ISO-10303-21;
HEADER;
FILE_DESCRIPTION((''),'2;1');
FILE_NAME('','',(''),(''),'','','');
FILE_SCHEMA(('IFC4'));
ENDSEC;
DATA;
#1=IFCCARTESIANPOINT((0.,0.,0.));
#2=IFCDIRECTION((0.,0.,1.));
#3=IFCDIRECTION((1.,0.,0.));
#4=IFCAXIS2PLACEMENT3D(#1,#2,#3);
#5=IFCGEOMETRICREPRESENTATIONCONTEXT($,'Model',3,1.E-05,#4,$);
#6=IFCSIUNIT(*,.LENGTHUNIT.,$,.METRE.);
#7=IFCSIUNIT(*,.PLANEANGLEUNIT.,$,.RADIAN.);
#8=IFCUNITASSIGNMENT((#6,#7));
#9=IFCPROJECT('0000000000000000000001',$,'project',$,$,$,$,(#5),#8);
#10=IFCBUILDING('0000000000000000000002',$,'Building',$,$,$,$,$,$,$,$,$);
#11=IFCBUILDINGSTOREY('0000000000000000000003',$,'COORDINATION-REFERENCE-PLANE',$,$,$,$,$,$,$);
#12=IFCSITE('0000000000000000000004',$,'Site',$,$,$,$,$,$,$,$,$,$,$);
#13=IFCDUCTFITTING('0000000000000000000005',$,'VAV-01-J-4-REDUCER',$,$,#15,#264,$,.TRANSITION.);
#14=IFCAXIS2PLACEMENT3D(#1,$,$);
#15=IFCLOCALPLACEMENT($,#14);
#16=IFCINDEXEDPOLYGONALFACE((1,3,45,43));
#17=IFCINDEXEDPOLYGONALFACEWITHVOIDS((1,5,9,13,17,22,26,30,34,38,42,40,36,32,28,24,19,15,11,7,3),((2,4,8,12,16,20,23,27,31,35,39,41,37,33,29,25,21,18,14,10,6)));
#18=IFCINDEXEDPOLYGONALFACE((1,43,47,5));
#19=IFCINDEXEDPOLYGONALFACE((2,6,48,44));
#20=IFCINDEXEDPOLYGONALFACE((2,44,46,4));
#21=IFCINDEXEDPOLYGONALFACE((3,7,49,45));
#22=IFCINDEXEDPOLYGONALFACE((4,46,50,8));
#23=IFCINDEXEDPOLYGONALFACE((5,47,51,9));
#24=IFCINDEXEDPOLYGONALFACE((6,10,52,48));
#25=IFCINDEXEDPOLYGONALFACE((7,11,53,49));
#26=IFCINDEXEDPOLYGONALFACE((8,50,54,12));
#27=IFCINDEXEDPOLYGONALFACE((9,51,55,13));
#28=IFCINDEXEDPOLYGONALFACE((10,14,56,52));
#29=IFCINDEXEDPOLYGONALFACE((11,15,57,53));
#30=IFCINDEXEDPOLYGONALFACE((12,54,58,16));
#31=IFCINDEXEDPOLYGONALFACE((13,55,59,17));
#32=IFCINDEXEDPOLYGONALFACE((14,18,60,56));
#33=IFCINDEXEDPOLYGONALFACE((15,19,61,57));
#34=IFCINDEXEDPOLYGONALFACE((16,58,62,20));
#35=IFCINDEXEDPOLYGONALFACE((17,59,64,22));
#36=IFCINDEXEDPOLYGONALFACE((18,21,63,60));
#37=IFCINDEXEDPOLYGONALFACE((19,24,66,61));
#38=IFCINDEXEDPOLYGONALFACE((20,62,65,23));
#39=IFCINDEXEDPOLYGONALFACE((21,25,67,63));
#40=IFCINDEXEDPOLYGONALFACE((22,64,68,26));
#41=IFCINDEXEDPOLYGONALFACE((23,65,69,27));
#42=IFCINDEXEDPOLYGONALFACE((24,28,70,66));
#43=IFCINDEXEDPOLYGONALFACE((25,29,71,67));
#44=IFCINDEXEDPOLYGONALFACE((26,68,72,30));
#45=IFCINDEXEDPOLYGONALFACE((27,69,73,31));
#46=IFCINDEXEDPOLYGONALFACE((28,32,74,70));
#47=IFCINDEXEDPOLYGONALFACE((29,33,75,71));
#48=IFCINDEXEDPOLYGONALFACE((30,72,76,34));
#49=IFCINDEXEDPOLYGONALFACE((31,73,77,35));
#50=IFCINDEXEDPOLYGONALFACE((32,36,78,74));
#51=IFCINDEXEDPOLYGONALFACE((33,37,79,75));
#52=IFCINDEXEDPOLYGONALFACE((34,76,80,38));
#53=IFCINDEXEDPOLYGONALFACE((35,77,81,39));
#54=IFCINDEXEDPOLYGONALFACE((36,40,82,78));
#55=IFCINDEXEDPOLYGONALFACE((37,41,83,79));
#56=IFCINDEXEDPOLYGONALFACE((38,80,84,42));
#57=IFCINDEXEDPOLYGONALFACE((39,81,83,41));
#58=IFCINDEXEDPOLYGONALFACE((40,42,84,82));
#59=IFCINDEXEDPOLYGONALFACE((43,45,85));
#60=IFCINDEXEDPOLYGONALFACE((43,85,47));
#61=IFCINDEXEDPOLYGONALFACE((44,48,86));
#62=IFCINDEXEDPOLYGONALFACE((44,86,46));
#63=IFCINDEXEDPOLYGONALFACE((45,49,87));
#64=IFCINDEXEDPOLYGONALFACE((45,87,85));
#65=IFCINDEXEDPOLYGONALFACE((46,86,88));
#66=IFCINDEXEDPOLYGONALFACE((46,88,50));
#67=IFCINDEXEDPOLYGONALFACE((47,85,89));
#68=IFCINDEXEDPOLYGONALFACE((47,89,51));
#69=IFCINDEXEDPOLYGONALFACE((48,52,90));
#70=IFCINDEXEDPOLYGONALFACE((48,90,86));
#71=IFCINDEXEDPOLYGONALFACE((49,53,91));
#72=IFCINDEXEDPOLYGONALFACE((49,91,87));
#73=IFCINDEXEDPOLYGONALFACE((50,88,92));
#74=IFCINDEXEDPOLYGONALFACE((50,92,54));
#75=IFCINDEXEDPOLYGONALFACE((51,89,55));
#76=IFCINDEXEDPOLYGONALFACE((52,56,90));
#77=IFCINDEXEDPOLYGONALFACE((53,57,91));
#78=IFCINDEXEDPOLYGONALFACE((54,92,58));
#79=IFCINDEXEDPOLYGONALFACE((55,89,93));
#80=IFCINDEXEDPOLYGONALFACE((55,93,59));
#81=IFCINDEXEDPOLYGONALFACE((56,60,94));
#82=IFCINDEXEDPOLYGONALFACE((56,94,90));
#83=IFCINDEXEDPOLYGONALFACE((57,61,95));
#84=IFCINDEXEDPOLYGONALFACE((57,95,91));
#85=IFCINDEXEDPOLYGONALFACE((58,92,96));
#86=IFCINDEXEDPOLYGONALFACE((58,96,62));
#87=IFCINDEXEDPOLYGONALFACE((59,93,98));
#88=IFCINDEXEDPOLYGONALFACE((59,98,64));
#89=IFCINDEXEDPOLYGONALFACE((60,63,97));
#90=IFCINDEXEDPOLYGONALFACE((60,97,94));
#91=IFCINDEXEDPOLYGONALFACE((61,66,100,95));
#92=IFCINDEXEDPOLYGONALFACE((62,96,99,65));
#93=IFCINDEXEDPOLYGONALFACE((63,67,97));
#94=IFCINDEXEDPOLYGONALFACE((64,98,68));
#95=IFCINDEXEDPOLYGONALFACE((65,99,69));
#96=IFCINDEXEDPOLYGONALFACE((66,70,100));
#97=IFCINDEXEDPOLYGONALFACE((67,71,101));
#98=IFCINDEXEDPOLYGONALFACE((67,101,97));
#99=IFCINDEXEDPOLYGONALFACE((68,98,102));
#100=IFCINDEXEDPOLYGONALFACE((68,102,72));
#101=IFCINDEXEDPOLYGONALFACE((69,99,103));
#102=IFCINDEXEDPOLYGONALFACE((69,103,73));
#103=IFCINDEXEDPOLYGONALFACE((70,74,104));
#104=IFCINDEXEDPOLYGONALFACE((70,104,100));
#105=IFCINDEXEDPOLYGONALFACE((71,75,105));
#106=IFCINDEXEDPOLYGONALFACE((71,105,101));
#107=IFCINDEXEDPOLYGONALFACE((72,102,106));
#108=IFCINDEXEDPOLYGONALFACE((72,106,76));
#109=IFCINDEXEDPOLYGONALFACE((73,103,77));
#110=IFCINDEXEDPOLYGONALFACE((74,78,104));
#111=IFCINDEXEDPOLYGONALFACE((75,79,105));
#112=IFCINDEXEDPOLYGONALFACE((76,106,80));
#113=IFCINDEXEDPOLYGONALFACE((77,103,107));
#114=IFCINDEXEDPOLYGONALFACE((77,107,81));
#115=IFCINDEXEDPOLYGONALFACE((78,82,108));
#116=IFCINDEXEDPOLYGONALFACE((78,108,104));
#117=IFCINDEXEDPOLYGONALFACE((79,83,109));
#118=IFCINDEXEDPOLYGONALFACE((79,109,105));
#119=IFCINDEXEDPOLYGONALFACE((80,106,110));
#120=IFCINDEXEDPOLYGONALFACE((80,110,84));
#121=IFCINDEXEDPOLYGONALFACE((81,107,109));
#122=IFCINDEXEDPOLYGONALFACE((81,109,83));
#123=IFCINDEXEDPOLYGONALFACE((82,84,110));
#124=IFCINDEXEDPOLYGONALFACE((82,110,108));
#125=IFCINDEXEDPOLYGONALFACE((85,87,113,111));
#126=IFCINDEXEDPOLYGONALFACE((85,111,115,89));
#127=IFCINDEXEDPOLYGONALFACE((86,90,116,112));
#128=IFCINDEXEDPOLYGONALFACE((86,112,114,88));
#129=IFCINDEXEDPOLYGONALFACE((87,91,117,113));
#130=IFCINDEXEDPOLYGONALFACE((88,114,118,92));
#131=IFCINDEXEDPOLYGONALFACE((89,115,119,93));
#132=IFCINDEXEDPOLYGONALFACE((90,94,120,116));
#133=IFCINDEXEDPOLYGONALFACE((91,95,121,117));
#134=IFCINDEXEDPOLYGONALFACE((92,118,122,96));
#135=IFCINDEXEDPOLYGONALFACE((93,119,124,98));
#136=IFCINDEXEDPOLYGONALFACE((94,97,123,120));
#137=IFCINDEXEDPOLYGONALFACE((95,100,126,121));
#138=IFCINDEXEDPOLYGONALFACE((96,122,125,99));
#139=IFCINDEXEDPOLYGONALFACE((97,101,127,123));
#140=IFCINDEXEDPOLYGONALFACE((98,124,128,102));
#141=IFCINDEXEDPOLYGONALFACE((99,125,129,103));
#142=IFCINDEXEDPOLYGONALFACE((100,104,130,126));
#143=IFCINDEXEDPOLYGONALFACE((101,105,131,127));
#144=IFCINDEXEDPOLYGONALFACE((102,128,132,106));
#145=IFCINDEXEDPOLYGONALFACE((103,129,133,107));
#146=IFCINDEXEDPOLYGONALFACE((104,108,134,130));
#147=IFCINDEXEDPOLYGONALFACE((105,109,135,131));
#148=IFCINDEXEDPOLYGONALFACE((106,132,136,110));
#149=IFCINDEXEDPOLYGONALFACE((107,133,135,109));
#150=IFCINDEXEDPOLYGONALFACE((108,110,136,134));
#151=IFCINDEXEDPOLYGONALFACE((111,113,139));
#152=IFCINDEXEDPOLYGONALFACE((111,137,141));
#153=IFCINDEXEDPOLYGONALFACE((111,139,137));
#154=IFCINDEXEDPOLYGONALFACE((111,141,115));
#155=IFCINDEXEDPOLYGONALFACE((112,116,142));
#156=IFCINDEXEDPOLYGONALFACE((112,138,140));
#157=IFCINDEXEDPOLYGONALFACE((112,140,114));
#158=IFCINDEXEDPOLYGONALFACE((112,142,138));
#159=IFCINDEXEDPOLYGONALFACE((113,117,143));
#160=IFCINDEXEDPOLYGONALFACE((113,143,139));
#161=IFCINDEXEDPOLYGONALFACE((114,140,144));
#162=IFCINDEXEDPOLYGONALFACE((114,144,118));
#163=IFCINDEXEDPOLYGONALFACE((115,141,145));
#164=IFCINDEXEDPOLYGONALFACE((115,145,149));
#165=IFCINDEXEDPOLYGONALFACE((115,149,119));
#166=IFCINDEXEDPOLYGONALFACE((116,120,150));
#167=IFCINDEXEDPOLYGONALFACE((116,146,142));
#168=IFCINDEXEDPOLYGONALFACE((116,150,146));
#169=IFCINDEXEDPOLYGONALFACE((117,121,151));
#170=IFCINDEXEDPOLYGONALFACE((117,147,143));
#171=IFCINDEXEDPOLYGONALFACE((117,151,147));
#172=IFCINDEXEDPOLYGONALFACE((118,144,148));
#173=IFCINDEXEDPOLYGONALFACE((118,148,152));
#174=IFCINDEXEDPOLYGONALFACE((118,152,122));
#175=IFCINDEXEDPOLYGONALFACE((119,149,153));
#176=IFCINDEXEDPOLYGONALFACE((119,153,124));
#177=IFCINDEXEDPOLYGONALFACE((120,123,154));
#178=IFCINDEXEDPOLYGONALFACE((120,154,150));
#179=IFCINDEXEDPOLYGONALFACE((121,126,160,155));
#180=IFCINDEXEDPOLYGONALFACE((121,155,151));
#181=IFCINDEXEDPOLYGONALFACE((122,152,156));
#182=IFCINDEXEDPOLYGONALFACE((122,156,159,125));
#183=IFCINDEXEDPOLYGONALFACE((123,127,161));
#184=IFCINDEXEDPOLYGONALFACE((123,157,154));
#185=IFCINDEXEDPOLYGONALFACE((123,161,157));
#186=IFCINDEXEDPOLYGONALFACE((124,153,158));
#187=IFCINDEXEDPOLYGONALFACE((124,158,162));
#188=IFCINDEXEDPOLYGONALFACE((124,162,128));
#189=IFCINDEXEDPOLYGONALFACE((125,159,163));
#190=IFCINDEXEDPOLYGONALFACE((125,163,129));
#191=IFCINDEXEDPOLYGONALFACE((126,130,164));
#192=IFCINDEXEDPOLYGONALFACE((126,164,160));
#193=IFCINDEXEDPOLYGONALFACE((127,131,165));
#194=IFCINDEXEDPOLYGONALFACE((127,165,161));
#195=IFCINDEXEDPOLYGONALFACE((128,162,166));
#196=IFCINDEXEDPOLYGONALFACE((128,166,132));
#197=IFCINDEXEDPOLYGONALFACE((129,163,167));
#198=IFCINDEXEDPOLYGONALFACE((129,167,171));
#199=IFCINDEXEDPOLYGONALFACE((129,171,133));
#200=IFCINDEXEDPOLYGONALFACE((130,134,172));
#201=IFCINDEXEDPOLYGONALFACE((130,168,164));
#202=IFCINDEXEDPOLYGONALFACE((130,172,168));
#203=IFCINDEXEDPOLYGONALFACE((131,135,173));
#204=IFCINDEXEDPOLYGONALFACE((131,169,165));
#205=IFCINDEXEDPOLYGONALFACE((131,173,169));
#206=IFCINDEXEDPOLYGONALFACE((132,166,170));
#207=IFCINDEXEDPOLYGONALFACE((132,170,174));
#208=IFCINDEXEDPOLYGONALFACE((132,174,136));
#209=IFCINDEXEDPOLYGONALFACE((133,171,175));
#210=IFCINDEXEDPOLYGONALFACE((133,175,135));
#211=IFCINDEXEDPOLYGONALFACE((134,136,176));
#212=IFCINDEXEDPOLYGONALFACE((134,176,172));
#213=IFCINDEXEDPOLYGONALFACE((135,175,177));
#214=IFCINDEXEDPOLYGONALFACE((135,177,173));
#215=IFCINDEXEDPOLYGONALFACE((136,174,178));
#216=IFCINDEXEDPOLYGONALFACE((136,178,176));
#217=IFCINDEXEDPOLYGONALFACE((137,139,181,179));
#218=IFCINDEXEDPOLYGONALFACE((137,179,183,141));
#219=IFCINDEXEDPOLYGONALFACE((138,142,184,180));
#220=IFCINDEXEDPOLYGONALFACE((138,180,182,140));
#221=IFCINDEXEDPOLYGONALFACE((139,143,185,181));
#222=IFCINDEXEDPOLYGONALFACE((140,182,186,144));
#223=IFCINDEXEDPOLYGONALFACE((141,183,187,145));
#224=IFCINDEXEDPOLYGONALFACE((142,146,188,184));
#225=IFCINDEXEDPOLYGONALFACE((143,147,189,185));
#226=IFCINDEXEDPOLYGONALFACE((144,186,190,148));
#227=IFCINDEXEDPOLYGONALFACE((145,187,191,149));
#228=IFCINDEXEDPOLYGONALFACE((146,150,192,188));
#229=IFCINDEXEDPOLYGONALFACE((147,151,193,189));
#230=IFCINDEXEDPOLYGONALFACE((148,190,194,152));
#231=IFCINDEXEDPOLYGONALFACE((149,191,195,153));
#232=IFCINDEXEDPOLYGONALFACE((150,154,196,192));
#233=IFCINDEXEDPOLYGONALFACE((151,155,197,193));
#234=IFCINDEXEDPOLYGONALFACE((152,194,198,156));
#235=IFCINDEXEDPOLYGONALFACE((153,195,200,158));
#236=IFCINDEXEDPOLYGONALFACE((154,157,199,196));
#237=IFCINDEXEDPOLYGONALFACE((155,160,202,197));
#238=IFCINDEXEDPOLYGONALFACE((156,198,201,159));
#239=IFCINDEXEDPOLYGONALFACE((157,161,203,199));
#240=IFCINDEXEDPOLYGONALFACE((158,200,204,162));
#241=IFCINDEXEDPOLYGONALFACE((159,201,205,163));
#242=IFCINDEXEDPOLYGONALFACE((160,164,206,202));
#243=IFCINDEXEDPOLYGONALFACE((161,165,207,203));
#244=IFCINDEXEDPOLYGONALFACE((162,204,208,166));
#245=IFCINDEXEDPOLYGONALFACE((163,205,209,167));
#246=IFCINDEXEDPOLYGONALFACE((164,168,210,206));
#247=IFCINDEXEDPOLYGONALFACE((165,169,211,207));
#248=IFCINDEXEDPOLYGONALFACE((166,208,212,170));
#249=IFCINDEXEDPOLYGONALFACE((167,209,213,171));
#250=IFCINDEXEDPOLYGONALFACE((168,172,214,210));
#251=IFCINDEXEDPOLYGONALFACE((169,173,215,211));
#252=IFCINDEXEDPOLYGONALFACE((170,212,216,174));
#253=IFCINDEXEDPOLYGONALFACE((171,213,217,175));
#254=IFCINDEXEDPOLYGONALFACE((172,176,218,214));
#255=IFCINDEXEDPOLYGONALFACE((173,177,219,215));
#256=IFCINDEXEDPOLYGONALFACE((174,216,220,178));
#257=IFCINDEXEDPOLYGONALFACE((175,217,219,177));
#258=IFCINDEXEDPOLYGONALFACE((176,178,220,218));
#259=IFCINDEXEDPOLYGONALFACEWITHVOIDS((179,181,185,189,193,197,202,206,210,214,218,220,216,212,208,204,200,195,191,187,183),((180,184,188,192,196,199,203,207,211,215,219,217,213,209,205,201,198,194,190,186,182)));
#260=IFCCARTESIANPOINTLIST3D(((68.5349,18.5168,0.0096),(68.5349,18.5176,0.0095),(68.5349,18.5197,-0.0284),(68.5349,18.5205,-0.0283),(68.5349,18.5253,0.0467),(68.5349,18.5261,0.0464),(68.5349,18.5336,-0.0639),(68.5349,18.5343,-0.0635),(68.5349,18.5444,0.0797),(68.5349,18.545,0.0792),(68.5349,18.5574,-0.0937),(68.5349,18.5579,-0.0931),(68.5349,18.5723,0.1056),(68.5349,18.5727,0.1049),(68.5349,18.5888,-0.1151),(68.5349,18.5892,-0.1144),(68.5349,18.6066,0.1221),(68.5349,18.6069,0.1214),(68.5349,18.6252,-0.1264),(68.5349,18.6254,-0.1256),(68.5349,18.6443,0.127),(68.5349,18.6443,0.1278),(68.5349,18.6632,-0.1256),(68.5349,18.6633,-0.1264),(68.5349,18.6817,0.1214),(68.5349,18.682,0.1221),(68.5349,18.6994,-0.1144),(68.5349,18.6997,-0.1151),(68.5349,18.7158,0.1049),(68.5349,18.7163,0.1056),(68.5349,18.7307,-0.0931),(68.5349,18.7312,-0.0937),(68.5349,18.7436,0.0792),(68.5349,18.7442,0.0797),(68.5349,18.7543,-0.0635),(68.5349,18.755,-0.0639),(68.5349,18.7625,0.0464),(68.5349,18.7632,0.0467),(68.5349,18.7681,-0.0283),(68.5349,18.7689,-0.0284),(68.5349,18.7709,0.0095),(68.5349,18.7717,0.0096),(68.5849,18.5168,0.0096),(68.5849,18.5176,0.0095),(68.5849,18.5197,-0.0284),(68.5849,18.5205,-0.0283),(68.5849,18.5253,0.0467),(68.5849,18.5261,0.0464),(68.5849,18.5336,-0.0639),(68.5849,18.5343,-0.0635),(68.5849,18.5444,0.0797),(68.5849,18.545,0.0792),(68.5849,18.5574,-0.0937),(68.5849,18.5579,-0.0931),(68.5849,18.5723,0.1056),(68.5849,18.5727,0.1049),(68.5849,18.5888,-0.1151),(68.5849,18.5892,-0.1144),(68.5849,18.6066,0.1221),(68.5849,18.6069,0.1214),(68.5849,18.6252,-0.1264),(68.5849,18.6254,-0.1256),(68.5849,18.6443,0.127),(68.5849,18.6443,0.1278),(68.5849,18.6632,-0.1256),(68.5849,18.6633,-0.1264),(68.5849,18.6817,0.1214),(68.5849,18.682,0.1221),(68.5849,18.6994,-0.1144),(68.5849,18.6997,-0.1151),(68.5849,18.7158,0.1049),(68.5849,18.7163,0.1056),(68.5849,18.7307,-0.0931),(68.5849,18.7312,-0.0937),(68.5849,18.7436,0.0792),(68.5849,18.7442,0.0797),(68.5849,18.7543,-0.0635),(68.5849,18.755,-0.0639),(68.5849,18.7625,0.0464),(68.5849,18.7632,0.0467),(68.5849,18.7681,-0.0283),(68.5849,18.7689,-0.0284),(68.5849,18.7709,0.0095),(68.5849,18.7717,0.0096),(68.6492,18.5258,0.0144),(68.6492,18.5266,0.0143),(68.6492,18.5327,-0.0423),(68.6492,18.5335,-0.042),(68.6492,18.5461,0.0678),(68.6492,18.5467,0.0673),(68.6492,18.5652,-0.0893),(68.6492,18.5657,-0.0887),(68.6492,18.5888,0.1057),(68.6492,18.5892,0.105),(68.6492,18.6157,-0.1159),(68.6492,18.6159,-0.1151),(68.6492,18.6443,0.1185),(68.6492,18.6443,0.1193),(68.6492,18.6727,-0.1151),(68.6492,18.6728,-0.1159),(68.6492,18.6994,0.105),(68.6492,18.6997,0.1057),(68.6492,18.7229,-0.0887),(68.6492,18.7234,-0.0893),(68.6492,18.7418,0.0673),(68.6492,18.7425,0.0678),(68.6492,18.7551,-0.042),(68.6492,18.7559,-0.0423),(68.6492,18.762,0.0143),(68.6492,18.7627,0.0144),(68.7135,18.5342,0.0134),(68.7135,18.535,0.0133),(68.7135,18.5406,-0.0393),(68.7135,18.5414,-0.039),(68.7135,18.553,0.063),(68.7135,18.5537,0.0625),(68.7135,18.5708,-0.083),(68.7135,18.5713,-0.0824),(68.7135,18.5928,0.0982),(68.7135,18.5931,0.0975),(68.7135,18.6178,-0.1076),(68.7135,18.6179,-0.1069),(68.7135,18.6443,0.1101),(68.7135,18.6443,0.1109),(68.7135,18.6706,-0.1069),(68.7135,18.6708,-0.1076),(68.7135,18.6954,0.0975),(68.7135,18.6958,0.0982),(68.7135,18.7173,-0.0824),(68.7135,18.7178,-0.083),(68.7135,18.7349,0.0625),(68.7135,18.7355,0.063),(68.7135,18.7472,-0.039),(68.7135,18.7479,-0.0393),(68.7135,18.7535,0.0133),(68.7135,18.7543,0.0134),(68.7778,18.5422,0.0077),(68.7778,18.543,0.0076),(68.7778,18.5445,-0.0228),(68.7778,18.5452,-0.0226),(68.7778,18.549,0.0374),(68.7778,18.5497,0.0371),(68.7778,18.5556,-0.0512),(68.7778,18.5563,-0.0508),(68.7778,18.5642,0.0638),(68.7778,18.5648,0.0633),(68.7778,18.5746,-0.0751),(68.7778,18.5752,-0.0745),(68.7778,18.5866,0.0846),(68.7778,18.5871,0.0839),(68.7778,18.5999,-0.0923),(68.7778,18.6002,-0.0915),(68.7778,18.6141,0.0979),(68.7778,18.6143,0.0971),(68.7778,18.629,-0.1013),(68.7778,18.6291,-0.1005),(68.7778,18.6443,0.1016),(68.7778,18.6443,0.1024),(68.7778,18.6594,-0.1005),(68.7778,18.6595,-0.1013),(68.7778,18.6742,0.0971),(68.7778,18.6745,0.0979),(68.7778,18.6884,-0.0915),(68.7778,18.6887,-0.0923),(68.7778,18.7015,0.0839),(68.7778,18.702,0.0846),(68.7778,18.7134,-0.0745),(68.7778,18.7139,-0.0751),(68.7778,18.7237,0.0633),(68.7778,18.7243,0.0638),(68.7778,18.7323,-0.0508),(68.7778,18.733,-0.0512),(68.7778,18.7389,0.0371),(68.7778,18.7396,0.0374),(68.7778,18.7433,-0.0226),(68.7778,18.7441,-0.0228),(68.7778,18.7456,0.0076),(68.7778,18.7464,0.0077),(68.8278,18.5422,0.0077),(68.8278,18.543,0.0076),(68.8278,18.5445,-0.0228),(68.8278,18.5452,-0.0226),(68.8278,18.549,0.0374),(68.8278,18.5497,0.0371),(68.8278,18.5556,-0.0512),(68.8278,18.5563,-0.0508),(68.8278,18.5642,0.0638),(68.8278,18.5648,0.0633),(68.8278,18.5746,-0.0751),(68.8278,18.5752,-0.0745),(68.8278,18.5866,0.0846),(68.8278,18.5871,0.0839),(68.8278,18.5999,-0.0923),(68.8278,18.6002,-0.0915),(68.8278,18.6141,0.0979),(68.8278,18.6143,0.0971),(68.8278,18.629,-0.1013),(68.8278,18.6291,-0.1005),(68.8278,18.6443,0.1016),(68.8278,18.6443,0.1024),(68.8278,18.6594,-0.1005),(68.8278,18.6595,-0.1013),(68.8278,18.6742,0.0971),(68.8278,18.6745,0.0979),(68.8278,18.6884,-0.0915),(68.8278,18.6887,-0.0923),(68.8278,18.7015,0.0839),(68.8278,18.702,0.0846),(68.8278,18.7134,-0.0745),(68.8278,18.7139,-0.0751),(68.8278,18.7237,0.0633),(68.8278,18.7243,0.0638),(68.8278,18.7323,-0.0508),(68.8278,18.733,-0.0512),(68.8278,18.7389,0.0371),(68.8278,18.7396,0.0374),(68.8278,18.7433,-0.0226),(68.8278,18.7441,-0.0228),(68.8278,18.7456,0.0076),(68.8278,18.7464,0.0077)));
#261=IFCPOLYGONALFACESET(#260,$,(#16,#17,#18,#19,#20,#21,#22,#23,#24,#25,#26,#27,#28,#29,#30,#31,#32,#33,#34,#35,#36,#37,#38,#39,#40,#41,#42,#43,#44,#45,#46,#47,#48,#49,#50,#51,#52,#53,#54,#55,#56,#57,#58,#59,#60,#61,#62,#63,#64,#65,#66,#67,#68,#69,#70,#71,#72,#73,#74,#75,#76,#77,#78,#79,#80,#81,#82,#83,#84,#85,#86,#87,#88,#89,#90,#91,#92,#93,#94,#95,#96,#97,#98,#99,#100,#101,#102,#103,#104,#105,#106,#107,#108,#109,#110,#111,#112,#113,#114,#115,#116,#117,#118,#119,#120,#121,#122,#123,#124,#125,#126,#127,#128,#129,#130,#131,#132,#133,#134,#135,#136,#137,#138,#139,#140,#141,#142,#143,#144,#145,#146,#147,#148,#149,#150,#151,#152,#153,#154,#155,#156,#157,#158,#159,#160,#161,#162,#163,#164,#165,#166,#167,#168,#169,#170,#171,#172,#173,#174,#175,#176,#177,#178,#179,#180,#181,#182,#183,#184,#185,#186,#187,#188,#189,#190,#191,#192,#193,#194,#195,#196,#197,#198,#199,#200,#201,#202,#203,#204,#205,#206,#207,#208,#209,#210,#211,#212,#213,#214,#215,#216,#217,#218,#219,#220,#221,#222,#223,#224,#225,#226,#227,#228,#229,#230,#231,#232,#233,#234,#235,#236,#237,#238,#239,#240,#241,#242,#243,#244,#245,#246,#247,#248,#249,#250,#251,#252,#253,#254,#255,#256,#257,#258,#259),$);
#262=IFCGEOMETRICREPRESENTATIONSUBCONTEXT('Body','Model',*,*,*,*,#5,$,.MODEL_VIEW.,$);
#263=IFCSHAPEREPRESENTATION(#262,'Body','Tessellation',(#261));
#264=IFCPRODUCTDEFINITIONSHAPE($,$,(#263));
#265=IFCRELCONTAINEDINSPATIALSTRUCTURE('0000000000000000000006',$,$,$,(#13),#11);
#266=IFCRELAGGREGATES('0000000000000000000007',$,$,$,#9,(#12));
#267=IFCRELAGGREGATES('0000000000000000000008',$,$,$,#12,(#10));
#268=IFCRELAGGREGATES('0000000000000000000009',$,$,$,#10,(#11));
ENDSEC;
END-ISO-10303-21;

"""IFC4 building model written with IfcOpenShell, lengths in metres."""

from ifc_helpers import new_model, entity, si_unit, frame, origin_with_axes, place, context, subcontext, project, spatial, element, save


model = new_model("IFC4")

# Units and contexts
model_context = context("Model", 3, precision=1e-05, world=origin_with_axes())
body_context_1 = subcontext(model_context, "Body", "Model", "MODEL_VIEW")
ifc_project = project(units=[si_unit("LENGTHUNIT", "METRE"), si_unit("PLANEANGLEUNIT", "RADIAN")], contexts=[model_context])

# Site, building, storey
site = spatial("IfcSite", under=ifc_project, Name="Site")
building = spatial("IfcBuilding", under=site, Name="Building")
storey = spatial("IfcBuildingStorey", under=building, Name="COORDINATION-REFERENCE-PLANE")

# Duct fitting
for number, where, z_axis, x_axis, name in (
    (1, (68.5349, 18.6443, 0.0), (0.0, 1.0, 0.0), (0.0, 0.0, 1.0), "VAV-01-J-4-REDUCER"),
):
    element("IfcDuctFitting", number, at=place(None, frame(where, z_axis=z_axis, x_axis=x_axis)), inside=storey, Name=name, PredefinedType="TRANSITION", context=body_context_1, shape_type="SweptSolid", body=[
        entity("IfcRevolvedAreaSolid", entity("IfcArbitraryClosedProfileDef", "AREA", None, entity("IfcPolyline", [entity("IfcCartesianPoint", [0.1278, 0.0]), entity("IfcCartesianPoint", [0.1278, 0.05]), entity("IfcCartesianPoint", [0.1024, 0.2429]), entity("IfcCartesianPoint", [0.1024, 0.2929]), entity("IfcCartesianPoint", [0.1016, 0.2929]), entity("IfcCartesianPoint", [0.1016, 0.2429]), entity("IfcCartesianPoint", [0.127, 0.05]), entity("IfcCartesianPoint", [0.127, 0.0]), entity("IfcCartesianPoint", [0.1278, 0.0])])), entity("IfcAxis2Placement3D", entity("IfcCartesianPoint", [0.0, 0.0, 0.0])), entity("IfcAxis1Placement", entity("IfcCartesianPoint", [0.0, 0.0, 0.0]), entity("IfcDirection", [0.0, 1.0, 0.0])), 6.283185),
    ])

save(model, "model.ifc")
